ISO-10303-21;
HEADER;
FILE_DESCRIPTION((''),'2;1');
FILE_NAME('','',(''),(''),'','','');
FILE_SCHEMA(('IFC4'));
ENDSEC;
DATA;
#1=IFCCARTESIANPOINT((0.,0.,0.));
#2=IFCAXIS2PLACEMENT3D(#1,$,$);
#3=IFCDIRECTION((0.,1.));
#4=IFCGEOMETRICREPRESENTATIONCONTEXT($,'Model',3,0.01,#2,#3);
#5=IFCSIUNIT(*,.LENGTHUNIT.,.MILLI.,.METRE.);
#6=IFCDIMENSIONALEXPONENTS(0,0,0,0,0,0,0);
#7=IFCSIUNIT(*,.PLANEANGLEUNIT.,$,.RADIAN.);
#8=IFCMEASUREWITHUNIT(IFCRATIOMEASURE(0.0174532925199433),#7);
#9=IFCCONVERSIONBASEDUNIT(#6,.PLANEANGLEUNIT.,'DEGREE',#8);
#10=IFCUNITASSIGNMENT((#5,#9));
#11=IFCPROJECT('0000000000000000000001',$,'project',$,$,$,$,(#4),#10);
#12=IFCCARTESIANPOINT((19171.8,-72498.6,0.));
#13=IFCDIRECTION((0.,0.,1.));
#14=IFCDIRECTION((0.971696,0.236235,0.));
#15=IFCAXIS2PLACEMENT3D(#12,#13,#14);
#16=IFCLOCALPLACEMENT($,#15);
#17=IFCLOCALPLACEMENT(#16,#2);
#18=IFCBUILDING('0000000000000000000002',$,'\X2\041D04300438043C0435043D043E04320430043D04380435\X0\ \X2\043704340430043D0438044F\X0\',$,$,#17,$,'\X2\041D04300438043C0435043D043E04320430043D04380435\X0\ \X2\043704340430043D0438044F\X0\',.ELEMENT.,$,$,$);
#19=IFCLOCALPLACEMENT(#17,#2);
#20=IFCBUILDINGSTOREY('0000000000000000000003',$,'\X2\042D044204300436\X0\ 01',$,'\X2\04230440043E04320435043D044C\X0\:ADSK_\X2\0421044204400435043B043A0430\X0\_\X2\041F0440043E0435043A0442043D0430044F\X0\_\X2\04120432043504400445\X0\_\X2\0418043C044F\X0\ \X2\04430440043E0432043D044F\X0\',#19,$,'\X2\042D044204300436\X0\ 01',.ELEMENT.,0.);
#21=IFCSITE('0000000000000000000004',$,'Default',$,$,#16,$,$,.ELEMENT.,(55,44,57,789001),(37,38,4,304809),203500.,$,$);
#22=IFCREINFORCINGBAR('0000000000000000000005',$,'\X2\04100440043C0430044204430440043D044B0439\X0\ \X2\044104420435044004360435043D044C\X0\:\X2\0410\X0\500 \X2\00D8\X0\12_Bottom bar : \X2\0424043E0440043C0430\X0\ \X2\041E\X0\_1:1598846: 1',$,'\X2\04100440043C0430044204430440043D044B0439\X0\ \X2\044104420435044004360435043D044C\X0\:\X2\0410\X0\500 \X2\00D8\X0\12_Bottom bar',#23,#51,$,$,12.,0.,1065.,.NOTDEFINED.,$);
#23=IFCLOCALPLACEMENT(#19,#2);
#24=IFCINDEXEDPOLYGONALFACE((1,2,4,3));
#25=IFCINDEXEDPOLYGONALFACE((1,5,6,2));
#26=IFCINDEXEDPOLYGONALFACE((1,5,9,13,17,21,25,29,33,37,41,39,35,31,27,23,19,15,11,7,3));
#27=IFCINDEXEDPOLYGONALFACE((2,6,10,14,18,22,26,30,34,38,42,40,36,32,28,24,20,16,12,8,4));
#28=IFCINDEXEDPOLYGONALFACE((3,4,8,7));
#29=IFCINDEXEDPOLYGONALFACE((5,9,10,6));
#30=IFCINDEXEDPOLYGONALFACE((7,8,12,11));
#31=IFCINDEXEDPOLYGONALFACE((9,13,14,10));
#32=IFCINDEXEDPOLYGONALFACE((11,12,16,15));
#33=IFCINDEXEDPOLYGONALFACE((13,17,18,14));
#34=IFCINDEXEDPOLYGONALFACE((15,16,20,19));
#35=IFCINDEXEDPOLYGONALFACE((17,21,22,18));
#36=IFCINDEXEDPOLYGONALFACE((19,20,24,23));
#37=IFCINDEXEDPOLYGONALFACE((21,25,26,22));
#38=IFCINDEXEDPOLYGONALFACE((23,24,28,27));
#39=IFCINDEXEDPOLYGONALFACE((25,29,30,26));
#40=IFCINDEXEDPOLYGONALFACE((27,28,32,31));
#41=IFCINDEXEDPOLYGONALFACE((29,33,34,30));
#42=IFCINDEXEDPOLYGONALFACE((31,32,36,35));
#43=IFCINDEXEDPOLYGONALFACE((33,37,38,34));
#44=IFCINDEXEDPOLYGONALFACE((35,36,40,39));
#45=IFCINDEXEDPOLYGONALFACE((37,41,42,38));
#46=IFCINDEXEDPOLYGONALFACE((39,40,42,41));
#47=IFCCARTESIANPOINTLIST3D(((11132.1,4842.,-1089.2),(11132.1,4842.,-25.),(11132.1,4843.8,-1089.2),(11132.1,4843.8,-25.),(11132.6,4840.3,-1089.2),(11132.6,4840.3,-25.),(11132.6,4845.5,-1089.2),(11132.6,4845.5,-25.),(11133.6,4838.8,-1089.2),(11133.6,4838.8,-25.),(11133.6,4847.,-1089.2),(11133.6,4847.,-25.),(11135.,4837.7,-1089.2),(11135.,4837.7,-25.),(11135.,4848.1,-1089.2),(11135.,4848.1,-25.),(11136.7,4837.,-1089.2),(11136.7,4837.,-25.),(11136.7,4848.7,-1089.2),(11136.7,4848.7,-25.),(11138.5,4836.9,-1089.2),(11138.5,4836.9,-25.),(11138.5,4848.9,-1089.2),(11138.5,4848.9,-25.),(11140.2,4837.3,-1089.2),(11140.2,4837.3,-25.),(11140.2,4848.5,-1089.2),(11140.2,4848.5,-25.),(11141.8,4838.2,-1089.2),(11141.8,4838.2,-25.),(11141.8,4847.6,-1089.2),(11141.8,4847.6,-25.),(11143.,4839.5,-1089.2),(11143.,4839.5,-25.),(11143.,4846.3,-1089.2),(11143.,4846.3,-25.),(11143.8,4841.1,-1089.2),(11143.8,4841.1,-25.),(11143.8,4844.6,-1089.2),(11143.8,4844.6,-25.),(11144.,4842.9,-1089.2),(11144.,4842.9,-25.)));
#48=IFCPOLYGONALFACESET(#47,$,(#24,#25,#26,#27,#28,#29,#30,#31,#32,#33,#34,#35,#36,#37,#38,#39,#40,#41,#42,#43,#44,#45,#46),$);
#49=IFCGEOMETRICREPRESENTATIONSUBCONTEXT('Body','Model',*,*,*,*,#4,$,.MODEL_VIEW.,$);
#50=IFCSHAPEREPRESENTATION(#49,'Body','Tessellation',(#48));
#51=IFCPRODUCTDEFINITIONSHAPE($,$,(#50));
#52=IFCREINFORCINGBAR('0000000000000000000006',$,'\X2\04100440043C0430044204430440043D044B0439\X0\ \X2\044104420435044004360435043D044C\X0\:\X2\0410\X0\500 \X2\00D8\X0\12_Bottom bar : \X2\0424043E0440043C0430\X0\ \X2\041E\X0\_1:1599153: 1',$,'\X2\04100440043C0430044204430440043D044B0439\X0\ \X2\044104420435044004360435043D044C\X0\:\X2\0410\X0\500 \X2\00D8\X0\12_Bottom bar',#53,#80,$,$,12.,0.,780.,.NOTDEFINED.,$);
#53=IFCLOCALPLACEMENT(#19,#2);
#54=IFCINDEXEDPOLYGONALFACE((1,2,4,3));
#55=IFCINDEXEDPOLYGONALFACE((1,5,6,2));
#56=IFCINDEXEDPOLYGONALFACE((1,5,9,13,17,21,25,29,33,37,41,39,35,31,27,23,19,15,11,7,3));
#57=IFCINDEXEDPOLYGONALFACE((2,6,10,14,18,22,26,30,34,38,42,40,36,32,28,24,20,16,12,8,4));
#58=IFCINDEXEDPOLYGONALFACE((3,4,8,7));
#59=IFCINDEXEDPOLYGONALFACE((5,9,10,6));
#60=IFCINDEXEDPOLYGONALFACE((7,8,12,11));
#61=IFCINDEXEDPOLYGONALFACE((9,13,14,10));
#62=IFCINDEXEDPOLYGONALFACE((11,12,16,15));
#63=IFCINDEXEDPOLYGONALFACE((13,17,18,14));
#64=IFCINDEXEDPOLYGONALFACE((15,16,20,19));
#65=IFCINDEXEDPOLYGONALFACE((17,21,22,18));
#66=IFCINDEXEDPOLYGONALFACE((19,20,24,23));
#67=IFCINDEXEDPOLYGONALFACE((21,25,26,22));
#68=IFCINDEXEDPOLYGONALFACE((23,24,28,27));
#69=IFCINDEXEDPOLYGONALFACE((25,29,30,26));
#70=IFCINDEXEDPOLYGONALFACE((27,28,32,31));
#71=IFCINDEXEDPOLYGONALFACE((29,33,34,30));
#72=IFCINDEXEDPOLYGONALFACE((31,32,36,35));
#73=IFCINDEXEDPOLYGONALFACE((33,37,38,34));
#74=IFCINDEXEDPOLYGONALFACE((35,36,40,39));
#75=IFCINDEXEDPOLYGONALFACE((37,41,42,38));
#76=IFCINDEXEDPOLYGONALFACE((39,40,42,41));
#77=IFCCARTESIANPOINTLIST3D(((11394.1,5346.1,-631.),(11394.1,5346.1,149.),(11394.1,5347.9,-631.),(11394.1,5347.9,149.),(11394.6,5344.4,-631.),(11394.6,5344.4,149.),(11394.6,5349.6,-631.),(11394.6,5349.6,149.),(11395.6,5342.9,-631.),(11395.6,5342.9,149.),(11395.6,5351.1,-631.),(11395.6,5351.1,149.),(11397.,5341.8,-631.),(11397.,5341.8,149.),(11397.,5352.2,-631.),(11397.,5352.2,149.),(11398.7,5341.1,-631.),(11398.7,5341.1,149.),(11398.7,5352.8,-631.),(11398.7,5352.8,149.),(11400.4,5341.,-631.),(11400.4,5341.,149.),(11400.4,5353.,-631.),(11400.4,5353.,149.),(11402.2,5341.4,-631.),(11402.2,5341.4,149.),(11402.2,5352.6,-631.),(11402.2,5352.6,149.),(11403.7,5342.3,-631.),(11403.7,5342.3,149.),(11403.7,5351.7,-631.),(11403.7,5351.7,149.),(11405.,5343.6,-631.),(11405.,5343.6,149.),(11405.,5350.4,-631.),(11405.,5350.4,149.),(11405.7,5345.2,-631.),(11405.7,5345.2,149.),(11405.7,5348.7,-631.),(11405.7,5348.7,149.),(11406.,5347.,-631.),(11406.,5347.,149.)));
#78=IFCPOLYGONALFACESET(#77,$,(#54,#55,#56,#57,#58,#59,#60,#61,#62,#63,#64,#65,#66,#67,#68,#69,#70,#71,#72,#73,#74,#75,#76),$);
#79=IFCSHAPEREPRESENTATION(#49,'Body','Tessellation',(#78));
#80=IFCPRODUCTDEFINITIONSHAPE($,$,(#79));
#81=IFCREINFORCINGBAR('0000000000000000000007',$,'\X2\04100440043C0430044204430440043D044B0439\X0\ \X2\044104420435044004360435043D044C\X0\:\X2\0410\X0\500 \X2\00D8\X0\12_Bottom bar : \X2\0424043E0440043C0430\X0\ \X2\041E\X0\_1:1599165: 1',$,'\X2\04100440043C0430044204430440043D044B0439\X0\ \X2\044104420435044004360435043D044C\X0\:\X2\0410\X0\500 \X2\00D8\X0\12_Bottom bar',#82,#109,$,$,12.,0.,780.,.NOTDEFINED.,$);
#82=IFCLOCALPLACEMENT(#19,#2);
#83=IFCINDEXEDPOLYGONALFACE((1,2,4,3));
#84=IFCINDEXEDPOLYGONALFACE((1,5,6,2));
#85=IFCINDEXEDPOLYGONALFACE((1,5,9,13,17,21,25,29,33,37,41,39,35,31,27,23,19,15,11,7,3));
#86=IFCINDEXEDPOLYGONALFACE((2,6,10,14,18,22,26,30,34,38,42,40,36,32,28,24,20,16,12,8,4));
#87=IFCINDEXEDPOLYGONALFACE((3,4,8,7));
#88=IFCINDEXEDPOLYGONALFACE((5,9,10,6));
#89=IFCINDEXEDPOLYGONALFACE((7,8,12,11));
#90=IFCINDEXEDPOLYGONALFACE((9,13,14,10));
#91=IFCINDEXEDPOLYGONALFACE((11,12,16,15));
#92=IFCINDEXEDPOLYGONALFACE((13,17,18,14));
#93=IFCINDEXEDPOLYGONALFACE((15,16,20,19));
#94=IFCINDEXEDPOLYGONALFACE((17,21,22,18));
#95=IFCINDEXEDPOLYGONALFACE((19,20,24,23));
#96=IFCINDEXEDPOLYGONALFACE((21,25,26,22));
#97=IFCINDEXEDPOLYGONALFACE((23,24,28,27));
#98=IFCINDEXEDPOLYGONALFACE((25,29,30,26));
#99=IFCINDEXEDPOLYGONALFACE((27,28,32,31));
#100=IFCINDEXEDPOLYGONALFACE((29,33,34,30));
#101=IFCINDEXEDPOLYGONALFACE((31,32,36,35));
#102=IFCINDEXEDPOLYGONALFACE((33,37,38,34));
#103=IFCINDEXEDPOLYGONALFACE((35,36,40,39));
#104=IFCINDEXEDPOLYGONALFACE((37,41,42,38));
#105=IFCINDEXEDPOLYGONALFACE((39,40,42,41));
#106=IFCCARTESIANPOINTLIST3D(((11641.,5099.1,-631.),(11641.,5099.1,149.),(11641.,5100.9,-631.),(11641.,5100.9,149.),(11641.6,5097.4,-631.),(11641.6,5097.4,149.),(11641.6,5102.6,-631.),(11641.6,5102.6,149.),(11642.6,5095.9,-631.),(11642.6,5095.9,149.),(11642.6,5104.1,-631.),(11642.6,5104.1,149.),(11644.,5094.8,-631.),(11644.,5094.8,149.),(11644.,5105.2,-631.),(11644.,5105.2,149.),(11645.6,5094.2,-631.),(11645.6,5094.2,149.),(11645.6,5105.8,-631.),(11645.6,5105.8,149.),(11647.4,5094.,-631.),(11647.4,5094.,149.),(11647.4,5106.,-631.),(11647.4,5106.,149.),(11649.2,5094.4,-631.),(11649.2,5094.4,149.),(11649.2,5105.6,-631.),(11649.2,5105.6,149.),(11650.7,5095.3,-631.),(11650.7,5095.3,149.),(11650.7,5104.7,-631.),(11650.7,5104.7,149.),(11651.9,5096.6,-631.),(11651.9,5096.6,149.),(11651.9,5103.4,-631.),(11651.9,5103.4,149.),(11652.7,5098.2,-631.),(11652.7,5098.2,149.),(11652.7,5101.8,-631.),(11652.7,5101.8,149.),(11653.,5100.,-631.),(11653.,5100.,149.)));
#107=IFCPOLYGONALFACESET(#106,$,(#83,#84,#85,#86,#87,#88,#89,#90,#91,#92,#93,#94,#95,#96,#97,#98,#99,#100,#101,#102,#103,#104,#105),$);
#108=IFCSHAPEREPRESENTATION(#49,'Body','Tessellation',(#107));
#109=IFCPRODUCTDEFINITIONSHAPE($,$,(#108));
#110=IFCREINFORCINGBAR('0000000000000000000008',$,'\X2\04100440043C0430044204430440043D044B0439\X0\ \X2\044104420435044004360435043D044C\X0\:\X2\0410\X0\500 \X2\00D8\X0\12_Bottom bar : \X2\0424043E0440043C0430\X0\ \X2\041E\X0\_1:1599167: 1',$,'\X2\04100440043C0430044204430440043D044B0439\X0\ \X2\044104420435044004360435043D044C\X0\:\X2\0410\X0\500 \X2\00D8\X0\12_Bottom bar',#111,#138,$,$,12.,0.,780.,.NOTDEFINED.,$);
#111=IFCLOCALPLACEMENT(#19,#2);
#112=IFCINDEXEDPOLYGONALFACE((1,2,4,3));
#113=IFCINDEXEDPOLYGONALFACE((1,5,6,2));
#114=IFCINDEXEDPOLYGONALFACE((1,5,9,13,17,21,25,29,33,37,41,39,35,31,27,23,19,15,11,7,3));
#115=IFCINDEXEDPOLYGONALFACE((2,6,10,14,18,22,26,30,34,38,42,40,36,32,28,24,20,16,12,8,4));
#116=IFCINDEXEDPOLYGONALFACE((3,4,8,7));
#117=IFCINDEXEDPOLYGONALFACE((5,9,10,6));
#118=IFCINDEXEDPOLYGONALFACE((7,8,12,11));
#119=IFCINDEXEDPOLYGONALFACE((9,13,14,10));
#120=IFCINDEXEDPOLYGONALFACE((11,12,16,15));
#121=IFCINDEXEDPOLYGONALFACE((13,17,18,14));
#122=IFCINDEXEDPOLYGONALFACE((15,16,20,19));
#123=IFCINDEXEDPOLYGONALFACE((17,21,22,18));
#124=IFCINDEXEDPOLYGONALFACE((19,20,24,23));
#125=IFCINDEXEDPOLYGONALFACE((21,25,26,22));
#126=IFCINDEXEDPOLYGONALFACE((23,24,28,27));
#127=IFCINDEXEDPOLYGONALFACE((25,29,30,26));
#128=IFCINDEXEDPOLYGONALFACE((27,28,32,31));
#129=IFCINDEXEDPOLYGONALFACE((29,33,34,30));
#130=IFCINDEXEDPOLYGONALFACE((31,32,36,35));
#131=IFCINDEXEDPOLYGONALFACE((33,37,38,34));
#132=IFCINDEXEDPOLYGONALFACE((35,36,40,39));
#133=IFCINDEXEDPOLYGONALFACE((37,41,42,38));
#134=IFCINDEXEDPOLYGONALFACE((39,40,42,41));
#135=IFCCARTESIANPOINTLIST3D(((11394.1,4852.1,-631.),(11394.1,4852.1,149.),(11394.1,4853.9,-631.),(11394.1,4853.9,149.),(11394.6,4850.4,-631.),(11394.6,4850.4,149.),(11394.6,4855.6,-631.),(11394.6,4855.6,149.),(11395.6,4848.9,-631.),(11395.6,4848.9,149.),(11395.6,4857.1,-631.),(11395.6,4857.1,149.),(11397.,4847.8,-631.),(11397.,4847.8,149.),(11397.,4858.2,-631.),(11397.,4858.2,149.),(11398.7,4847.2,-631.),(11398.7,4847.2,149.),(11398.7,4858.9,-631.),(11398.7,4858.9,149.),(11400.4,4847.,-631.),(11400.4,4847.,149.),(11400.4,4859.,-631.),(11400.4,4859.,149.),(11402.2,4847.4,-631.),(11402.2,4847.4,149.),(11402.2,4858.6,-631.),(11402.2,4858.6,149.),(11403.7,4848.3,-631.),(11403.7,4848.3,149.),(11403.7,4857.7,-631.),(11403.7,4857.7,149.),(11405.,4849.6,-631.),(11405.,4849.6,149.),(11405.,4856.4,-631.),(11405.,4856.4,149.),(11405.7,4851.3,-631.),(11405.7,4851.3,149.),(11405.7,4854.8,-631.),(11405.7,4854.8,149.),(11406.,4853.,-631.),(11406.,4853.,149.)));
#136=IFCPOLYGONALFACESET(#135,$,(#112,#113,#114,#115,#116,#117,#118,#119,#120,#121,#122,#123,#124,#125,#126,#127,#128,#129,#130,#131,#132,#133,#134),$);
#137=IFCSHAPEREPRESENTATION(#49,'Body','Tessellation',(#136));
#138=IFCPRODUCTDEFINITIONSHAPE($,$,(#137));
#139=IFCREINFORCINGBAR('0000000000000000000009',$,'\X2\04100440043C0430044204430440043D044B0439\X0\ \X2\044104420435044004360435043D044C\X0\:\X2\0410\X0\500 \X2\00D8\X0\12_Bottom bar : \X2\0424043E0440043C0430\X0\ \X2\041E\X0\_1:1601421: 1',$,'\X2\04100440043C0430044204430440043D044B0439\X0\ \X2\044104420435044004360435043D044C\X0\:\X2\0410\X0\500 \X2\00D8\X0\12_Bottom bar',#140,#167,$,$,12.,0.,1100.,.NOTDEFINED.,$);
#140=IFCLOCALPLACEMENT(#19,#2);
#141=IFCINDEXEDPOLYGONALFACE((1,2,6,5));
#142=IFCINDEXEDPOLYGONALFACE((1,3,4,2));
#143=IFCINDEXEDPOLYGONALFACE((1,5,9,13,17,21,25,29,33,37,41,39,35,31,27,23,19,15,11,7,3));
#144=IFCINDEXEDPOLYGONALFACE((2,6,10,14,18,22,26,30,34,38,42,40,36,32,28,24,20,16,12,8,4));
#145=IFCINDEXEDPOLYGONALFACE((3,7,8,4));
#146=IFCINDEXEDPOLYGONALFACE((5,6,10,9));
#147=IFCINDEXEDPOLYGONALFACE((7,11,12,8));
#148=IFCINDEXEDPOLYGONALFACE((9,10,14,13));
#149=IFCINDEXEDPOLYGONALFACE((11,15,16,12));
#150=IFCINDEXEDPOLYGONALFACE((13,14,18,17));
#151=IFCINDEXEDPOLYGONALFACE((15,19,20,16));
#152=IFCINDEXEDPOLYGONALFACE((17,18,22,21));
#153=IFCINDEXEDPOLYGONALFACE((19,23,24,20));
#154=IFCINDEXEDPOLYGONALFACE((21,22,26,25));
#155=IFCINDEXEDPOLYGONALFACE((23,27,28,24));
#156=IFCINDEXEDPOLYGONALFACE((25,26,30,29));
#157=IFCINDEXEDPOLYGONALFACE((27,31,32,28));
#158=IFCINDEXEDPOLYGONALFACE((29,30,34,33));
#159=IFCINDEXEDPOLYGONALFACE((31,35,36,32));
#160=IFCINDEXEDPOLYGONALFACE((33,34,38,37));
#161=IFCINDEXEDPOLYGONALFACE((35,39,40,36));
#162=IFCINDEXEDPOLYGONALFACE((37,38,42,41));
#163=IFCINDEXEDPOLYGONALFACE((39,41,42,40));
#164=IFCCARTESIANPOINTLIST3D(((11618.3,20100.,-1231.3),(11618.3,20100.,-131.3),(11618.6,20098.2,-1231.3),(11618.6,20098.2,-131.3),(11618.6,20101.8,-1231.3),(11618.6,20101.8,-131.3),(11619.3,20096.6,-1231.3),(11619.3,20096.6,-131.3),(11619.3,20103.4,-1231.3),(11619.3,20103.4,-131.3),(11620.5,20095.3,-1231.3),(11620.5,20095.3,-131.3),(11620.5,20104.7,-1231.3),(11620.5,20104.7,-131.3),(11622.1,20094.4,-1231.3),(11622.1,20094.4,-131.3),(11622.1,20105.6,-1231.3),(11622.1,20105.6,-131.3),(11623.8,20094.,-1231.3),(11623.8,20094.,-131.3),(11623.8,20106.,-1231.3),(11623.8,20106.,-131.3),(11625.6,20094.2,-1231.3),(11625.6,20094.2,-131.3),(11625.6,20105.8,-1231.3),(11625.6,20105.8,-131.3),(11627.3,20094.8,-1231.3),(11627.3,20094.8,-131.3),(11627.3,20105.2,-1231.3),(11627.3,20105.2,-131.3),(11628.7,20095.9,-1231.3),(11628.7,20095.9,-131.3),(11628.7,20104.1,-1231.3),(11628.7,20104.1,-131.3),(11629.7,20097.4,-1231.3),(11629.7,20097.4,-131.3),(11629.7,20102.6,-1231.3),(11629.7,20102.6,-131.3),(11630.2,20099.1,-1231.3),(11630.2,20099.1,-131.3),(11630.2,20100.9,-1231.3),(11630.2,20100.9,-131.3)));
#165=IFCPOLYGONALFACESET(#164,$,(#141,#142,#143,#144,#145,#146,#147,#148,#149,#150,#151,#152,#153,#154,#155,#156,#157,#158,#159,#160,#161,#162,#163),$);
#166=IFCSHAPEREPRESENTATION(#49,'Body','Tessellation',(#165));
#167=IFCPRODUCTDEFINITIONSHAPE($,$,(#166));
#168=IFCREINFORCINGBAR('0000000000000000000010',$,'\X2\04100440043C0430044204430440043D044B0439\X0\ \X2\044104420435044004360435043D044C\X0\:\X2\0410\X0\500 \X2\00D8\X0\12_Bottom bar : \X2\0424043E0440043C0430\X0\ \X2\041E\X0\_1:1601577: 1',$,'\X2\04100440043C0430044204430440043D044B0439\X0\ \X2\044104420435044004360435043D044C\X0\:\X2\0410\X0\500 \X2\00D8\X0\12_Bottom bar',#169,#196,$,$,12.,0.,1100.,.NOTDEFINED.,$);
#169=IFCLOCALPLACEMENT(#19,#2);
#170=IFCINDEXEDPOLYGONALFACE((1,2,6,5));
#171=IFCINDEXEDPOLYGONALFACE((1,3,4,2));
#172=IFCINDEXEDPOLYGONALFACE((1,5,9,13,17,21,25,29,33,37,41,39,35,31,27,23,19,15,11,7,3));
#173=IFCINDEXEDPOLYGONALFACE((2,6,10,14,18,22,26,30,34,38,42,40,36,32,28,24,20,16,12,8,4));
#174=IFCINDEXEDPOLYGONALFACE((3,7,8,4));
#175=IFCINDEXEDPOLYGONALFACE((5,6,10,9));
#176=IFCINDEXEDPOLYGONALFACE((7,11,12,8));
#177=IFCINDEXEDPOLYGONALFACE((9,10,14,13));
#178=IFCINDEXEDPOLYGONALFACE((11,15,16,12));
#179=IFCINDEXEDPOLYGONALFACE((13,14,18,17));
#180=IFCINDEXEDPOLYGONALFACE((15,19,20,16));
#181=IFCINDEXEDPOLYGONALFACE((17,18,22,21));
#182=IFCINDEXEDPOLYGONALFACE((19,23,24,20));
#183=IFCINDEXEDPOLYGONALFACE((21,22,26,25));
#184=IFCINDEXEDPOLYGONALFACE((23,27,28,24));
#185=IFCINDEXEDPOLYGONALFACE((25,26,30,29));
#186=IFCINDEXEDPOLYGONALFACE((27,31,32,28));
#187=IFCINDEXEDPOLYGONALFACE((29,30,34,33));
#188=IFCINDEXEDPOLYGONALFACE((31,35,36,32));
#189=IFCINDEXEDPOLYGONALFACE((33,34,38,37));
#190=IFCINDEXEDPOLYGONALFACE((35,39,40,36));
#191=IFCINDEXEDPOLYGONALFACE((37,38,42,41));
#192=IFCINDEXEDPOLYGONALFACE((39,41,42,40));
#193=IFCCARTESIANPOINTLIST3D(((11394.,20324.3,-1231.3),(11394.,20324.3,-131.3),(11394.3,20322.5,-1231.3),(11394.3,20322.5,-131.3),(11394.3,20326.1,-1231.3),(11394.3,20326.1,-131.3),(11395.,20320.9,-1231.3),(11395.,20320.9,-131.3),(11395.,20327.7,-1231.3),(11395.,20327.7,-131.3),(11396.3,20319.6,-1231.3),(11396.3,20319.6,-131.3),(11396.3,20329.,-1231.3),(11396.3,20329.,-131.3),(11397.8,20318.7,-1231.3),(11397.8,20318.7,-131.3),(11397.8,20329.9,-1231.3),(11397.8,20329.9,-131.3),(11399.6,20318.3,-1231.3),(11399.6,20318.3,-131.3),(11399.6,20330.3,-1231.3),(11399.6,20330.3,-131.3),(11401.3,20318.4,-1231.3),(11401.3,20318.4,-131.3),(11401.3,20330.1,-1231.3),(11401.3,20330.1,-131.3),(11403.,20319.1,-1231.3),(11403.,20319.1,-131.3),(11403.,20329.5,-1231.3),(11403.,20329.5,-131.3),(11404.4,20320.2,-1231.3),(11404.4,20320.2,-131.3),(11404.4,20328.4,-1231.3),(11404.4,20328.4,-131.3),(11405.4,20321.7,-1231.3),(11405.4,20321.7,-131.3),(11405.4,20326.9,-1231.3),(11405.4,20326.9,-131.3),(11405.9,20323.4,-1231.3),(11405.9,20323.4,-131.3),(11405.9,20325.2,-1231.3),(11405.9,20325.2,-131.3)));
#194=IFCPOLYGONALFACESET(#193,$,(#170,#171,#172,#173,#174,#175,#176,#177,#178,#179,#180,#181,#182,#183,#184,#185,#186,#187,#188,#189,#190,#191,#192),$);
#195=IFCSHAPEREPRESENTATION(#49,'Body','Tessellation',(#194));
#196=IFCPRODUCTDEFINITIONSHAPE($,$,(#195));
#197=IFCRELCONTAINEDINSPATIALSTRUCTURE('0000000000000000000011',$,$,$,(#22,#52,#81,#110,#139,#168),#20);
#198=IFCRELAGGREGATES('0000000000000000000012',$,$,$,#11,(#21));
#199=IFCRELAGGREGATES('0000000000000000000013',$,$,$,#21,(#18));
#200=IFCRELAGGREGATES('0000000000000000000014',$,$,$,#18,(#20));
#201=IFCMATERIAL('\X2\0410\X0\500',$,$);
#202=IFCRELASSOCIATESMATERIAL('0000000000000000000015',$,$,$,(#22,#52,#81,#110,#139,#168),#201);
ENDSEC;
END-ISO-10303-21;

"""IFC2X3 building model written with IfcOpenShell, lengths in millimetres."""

from ifc_helpers import new_model, entity, si_unit, converted_unit, direction, frame, origin, place, context, subcontext, project, spatial, material, element, save


model = new_model("IFC2X3")

# Units and contexts
model_context = context("Model", 3, precision=0.01, world=origin(), true_north=direction((0.0, 1.0)))
body_context = subcontext(model_context, "Body", "Model", "MODEL_VIEW")
ifc_project = project(units=[si_unit("LENGTHUNIT", "METRE", prefix="MILLI"), converted_unit("PLANEANGLEUNIT", "DEGREE", entity("IfcRatioMeasure", 0.0174532925199433), si_unit("PLANEANGLEUNIT", "RADIAN"), dimensions=[0, 0, 0, 0, 0, 0, 0])], contexts=[model_context])

# Site, building, storey
site_placement = place(None, frame((19171.8, -72498.6, 0.0), z_axis=(0.0, 0.0, 1.0), x_axis=(0.971696, 0.236235, 0.0)))
site = spatial("IfcSite", under=ifc_project, at=site_placement, Name="Default", CompositionType="ELEMENT", RefLatitude=(55, 44, 57, 789001), RefLongitude=(37, 38, 4, 304809), RefElevation=203500.0)
building_placement = place(site_placement, origin())
building = spatial("IfcBuilding", under=site, at=building_placement, Name="Наименование здания", LongName="Наименование здания", CompositionType="ELEMENT")
storey_placement = place(building_placement, origin())
storey = spatial("IfcBuildingStorey", under=building, at=storey_placement, Name="Этаж 01", ObjectType="Уровень:ADSK_Стрелка_Проектная_Вверх_Имя уровня", LongName="Этаж 01", CompositionType="ELEMENT", Elevation=0.0)

# Reinforcing bars
ifc_material = material(Name="А500")
placement = place(storey_placement, origin())
element("IfcReinforcingBar", 1, at=placement, inside=storey, material=ifc_material, Name="Арматурный стержень:А500 Ø12_Bottom bar : Форма О_1:1598846: 1", ObjectType="Арматурный стержень:А500 Ø12_Bottom bar", BarLength=1065.0, BarRole="NOTDEFINED", CrossSectionArea=0.0, NominalDiameter=12.0, context=body_context, shape_type="AdvancedSweptSolid", body=[
    entity("IfcSweptDiskSolid", entity("IfcCompositeCurve", [entity("IfcCompositeCurveSegment", "CONTINUOUS", True, entity("IfcPolyline", [entity("IfcCartesianPoint", [11138.0, 4842.9, -1089.2]), entity("IfcCartesianPoint", [11138.0, 4842.9, -25.0])]))], False), 6.0, None, 0.0, 1.0),
])
element("IfcReinforcingBar", 2, at=placement, inside=storey, material=ifc_material, Name="Арматурный стержень:А500 Ø12_Bottom bar : Форма О_1:1599153: 1", ObjectType="Арматурный стержень:А500 Ø12_Bottom bar", BarLength=780.0, BarRole="NOTDEFINED", CrossSectionArea=0.0, NominalDiameter=12.0, context=body_context, shape_type="AdvancedSweptSolid", body=[
    entity("IfcSweptDiskSolid", entity("IfcCompositeCurve", [entity("IfcCompositeCurveSegment", "CONTINUOUS", True, entity("IfcPolyline", [entity("IfcCartesianPoint", [11400.0, 5347.0, -631.0]), entity("IfcCartesianPoint", [11400.0, 5347.0, 149.0])]))], False), 6.0, None, 0.0, 1.0),
])
element("IfcReinforcingBar", 3, at=placement, inside=storey, material=ifc_material, Name="Арматурный стержень:А500 Ø12_Bottom bar : Форма О_1:1599165: 1", ObjectType="Арматурный стержень:А500 Ø12_Bottom bar", BarLength=780.0, BarRole="NOTDEFINED", CrossSectionArea=0.0, NominalDiameter=12.0, context=body_context, shape_type="AdvancedSweptSolid", body=[
    entity("IfcSweptDiskSolid", entity("IfcCompositeCurve", [entity("IfcCompositeCurveSegment", "CONTINUOUS", True, entity("IfcPolyline", [entity("IfcCartesianPoint", [11647.0, 5100.0, -631.0]), entity("IfcCartesianPoint", [11647.0, 5100.0, 149.0])]))], False), 6.0, None, 0.0, 1.0),
])
element("IfcReinforcingBar", 4, at=placement, inside=storey, material=ifc_material, Name="Арматурный стержень:А500 Ø12_Bottom bar : Форма О_1:1599167: 1", ObjectType="Арматурный стержень:А500 Ø12_Bottom bar", BarLength=780.0, BarRole="NOTDEFINED", CrossSectionArea=0.0, NominalDiameter=12.0, context=body_context, shape_type="AdvancedSweptSolid", body=[
    entity("IfcSweptDiskSolid", entity("IfcCompositeCurve", [entity("IfcCompositeCurveSegment", "CONTINUOUS", True, entity("IfcPolyline", [entity("IfcCartesianPoint", [11400.0, 4853.0, -631.0]), entity("IfcCartesianPoint", [11400.0, 4853.0, 149.0])]))], False), 6.0, None, 0.0, 1.0),
])
element("IfcReinforcingBar", 5, at=placement, inside=storey, material=ifc_material, Name="Арматурный стержень:А500 Ø12_Bottom bar : Форма О_1:1601421: 1", ObjectType="Арматурный стержень:А500 Ø12_Bottom bar", BarLength=1100.0, BarRole="NOTDEFINED", CrossSectionArea=0.0, NominalDiameter=12.0, context=body_context, shape_type="AdvancedSweptSolid", body=[
    entity("IfcSweptDiskSolid", entity("IfcCompositeCurve", [entity("IfcCompositeCurveSegment", "CONTINUOUS", True, entity("IfcPolyline", [entity("IfcCartesianPoint", [11624.3, 20100.0, -131.3]), entity("IfcCartesianPoint", [11624.3, 20100.0, -1231.3])]))], False), 6.0, None, 0.0, 1.0),
])
element("IfcReinforcingBar", 6, at=placement, inside=storey, material=ifc_material, Name="Арматурный стержень:А500 Ø12_Bottom bar : Форма О_1:1601577: 1", ObjectType="Арматурный стержень:А500 Ø12_Bottom bar", BarLength=1100.0, BarRole="NOTDEFINED", CrossSectionArea=0.0, NominalDiameter=12.0, context=body_context, shape_type="AdvancedSweptSolid", body=[
    entity("IfcSweptDiskSolid", entity("IfcCompositeCurve", [entity("IfcCompositeCurveSegment", "CONTINUOUS", True, entity("IfcPolyline", [entity("IfcCartesianPoint", [11400.0, 20324.3, -131.3]), entity("IfcCartesianPoint", [11400.0, 20324.3, -1231.3])]))], False), 6.0, None, 0.0, 1.0),
])

save(model, "model.ifc")
